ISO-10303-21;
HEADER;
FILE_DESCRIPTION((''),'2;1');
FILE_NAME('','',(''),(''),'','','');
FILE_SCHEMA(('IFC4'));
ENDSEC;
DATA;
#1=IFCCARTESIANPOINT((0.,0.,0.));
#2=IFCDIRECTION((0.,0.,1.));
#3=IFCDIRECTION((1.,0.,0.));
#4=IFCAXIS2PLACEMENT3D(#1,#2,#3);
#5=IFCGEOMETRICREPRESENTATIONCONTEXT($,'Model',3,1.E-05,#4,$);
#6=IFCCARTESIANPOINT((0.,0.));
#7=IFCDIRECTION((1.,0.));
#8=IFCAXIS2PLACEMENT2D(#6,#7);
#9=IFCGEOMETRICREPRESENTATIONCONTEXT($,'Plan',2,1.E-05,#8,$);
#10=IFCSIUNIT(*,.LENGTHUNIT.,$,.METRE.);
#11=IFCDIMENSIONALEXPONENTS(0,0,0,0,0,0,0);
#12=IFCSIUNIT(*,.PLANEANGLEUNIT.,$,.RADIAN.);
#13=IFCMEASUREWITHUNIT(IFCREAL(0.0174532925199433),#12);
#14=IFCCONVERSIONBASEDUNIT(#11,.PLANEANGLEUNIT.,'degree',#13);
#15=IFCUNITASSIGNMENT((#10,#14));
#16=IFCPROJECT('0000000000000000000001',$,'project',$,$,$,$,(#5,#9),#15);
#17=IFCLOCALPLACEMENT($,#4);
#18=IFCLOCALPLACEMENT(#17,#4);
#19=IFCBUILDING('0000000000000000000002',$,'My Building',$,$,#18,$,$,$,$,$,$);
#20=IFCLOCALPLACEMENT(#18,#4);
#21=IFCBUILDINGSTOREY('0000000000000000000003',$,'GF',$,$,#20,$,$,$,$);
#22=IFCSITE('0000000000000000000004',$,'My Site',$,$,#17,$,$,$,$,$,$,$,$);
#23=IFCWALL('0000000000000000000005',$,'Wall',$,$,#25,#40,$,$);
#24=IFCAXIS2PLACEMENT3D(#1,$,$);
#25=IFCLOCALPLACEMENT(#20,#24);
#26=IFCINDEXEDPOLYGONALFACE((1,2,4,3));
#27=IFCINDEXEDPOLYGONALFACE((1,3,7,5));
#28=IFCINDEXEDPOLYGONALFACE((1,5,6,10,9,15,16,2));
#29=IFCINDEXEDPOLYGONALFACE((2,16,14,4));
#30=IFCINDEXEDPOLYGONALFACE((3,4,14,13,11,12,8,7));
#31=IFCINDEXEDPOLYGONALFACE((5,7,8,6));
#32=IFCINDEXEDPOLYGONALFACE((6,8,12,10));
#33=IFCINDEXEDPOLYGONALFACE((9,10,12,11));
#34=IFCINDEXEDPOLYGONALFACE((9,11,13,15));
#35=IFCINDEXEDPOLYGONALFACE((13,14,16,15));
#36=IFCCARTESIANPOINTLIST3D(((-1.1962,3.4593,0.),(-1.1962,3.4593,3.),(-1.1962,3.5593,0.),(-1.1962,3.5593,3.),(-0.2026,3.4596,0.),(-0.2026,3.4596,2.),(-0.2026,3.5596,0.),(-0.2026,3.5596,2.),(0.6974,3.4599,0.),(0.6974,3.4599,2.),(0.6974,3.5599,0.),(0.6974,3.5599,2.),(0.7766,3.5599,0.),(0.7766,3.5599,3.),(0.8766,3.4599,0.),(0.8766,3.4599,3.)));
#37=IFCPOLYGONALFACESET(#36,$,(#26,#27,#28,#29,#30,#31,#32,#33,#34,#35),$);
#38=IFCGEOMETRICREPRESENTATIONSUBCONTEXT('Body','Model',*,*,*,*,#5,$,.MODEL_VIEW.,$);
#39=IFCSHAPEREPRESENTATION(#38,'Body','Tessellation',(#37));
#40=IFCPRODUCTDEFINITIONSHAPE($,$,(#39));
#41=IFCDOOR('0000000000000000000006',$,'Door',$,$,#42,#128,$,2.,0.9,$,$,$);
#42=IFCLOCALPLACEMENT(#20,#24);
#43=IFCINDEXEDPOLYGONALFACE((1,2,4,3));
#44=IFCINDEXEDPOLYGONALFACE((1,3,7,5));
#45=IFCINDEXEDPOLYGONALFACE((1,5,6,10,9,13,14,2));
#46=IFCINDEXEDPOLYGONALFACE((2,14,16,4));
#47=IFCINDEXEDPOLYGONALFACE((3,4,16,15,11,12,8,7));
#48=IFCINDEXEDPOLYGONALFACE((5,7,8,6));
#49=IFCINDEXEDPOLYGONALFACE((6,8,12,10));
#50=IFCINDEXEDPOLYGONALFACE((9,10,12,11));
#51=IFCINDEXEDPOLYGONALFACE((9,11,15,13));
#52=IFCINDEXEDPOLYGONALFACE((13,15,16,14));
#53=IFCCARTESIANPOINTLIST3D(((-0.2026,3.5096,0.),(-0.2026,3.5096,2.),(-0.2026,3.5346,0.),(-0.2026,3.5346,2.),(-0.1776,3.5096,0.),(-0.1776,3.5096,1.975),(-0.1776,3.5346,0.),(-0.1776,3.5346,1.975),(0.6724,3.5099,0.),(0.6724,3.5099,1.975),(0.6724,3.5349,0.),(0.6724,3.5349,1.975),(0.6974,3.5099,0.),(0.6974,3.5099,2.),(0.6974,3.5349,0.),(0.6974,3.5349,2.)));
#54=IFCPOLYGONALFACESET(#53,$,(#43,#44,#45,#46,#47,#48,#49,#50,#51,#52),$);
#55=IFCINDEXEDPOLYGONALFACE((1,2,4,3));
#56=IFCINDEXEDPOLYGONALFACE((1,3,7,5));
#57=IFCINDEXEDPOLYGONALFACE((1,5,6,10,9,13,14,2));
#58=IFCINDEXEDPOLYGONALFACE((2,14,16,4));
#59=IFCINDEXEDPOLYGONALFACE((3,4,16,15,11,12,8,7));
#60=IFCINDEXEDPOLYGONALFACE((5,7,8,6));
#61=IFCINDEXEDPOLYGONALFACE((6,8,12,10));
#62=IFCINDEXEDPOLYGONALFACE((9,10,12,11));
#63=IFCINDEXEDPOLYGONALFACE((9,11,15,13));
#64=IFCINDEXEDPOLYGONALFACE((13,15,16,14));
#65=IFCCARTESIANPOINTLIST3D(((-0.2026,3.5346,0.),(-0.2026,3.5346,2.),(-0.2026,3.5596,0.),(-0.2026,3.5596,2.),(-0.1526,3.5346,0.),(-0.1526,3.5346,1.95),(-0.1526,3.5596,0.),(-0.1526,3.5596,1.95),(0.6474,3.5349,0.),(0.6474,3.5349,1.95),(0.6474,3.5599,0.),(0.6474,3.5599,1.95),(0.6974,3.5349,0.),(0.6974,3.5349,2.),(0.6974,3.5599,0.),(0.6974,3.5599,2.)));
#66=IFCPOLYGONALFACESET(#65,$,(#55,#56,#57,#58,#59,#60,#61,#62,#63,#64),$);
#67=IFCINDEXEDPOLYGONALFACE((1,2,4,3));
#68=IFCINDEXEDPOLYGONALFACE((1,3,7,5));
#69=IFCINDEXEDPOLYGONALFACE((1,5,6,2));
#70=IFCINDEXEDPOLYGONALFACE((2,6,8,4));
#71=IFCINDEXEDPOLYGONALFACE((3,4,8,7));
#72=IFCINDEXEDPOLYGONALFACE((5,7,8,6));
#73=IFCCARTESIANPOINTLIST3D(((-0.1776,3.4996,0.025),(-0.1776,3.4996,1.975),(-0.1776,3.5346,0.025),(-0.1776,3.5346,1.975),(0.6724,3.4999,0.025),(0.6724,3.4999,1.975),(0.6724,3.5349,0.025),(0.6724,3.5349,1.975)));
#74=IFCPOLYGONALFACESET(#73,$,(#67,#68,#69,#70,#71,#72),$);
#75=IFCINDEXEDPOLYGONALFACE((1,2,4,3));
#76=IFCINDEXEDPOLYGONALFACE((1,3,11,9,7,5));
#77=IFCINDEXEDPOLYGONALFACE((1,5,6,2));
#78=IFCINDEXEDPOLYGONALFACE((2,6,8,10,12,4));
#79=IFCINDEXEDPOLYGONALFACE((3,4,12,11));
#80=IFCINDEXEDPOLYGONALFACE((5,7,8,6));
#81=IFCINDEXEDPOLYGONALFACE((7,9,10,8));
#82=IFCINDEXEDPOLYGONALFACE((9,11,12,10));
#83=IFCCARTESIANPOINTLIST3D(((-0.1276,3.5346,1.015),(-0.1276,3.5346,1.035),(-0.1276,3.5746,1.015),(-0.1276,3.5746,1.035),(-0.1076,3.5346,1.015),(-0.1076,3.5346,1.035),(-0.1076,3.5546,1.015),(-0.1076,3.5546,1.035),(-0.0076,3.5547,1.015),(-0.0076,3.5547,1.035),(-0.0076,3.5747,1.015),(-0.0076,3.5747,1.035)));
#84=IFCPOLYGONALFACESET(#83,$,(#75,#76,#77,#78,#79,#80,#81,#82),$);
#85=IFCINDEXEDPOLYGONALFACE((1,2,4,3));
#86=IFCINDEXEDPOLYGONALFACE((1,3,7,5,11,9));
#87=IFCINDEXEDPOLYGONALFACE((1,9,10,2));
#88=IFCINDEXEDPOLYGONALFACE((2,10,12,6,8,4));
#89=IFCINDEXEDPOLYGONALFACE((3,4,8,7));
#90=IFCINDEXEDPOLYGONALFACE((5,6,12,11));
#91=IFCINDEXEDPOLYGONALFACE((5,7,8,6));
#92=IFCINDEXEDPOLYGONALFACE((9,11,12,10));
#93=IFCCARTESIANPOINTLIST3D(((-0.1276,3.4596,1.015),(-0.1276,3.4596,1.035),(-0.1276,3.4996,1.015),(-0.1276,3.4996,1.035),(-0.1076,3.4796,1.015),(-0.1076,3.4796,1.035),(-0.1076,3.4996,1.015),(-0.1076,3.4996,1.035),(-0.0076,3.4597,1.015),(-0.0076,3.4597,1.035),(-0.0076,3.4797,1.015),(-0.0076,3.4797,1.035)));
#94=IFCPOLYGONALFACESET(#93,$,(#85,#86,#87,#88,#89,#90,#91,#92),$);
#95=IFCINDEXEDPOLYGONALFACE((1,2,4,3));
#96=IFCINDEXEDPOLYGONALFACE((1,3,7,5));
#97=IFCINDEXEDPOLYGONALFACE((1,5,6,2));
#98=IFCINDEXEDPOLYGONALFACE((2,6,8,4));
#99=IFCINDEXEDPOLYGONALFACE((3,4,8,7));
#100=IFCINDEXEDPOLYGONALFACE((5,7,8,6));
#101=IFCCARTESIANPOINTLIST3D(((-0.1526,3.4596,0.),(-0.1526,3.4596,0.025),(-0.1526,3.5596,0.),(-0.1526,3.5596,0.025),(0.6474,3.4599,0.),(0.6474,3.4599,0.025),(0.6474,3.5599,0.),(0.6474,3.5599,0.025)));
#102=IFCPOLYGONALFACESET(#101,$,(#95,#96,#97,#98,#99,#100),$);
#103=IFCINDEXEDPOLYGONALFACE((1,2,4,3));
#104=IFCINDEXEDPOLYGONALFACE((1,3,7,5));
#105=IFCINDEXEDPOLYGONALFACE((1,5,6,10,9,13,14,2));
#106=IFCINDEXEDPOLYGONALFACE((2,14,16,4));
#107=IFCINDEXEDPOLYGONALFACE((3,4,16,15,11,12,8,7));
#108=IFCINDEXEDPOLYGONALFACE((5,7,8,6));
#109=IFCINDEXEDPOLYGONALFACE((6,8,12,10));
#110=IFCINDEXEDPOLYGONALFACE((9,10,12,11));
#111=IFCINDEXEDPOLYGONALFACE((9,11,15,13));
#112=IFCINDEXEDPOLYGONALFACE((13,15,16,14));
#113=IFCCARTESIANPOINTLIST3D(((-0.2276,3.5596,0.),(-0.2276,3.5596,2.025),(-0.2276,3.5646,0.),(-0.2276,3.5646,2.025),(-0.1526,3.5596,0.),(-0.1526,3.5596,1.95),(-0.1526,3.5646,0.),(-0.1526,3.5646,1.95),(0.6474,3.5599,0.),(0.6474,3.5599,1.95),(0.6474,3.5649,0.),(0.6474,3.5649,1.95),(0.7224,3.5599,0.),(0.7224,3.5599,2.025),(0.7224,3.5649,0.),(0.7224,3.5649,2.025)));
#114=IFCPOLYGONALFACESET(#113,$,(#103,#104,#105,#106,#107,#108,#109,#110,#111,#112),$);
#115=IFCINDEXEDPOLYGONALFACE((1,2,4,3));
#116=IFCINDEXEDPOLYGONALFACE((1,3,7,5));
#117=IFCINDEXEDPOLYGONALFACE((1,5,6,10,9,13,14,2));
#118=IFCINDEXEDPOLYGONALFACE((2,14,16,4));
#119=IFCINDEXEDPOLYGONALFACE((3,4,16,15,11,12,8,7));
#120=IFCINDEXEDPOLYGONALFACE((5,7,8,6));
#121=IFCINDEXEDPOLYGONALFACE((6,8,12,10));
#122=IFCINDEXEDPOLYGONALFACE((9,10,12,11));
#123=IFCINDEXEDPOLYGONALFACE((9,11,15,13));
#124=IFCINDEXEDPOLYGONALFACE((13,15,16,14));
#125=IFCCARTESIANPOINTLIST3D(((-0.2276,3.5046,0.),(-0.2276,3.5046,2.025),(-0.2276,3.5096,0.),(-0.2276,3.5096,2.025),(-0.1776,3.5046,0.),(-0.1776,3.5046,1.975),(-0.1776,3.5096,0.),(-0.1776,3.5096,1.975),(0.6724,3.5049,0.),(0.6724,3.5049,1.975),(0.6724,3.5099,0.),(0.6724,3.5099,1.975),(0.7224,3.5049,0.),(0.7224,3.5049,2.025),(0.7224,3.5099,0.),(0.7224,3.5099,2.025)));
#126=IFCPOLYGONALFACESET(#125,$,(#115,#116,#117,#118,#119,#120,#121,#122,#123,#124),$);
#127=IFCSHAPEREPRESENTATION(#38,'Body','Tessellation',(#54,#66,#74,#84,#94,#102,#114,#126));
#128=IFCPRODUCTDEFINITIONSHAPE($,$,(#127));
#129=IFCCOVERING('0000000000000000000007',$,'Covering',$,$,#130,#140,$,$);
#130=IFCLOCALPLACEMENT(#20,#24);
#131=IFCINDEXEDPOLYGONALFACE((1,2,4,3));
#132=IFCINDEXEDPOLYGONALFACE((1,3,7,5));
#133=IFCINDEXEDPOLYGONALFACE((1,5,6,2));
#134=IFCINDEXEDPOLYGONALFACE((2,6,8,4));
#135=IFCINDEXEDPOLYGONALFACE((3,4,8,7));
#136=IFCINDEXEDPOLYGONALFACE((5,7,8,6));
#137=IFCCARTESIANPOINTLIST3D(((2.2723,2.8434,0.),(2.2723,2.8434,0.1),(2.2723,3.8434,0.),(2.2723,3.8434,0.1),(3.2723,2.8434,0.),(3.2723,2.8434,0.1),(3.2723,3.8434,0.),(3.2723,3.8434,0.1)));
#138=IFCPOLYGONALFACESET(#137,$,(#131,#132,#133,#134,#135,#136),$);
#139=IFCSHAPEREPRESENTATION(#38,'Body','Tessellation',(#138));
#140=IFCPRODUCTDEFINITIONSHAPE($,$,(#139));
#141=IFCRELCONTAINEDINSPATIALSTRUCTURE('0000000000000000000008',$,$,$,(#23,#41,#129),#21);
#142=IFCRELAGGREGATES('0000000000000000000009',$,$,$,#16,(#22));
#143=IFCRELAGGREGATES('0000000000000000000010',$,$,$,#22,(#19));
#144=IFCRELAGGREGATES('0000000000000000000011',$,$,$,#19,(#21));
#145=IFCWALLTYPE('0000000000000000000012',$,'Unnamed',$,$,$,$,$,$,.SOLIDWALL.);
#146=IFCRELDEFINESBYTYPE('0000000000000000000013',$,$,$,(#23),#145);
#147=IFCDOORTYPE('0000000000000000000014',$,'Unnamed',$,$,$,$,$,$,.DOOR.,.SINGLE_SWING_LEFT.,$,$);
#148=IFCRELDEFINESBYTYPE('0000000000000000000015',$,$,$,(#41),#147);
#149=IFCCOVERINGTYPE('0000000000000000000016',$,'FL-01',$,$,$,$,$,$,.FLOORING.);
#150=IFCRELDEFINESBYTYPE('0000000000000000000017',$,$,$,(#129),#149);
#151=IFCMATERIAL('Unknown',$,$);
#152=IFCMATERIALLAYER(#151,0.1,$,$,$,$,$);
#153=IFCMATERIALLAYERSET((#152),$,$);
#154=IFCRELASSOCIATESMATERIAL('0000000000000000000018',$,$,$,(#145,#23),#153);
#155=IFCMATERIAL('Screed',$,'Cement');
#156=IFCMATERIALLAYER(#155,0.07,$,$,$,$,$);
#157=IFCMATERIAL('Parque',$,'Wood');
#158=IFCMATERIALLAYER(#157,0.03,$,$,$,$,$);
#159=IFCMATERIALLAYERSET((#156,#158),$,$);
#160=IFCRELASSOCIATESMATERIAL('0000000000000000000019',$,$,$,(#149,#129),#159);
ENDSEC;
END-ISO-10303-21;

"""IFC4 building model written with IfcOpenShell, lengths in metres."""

from ifc_helpers import new_model, entity, si_unit, converted_unit, frame, origin_with_axes, origin_2d_with_axis, place, context, subcontext, project, spatial, line, indexed_curve, outline, extrude, shape, source, transform, mapped, material, layer, layer_set, layer_usage, type_object, type_shapes, element, fill, save


model = new_model("IFC4")

# Units and contexts
model_context = context("Model", 3, precision=1e-05, world=origin_with_axes())
plan_context = context("Plan", 2, precision=1e-05, world=origin_2d_with_axis())
body_context_1 = subcontext(model_context, "Body", "Model", "MODEL_VIEW")
body_context_2 = subcontext(plan_context, "Body", "Plan", "PLAN_VIEW")
ifc_project = project(units=[si_unit("LENGTHUNIT", "METRE"), converted_unit("PLANEANGLEUNIT", "degree", entity("IfcReal", 0.0174532925199433), si_unit("PLANEANGLEUNIT", "RADIAN"), dimensions=[0, 0, 0, 0, 0, 0, 0])], contexts=[model_context, plan_context])

# Site, building, storey
site_placement = place(None, origin_with_axes())
site = spatial("IfcSite", under=ifc_project, at=site_placement, Name="My Site")
building_placement = place(site_placement, origin_with_axes())
building = spatial("IfcBuilding", under=site, at=building_placement, Name="My Building")
storey_placement = place(building_placement, origin_with_axes())
storey = spatial("IfcBuildingStorey", under=building, at=storey_placement, Name="GF")

# Shared definitions
ifc_material_1 = material(Name="Unknown")

# Shared definitions
ifc_layer_1 = layer(ifc_material_1, 0.1)
ifc_layer_set_1 = layer_set([ifc_layer_1])
wall_type = type_object("IfcWallType", Name="Unnamed", PredefinedType="SOLIDWALL", material=ifc_layer_set_1)

# Wall, opening, door
ifc_layer_usage_1 = layer_usage(ifc_layer_set_1, "AXIS2", "POSITIVE", 0.0)
wall_1_placement = place(storey_placement, frame((0.7766, 3.5599, 0.0), z_axis=(0.0, 0.0, 1.0), x_axis=(-1.0, -0.000309, 0.0)))
wall_1 = element("IfcWall", 1, at=wall_1_placement, inside=storey, type_object=wall_type, material=ifc_layer_usage_1, Name="Wall", context=body_context_1, shape_type="SweptSolid", body=[
    extrude(outline(indexed_curve([(0.0, 0.0), (-0.1, 0.1), (1.9728, 0.1), (1.9728, 0.0)], segments=[line(1, 2, 3, 4, 1)])), origin_with_axes(), (0.0, 0.0, 1.0), 3.0),
])
shared_shape_1 = source(origin_with_axes(), body_context_1, "Body", "SweptSolid", [
    extrude(outline(indexed_curve([(0.0, 0.0), (0.9, 0.0), (0.9, 2.0), (0.0, 2.0)], segments=[line(1, 2, 3, 4, 1)])), frame((0.0, -0.6, 0.0), z_axis=(0.0, -1.0, 0.0), x_axis=(1.0, 0.0, 0.0)), (0.0, 0.0, -1.0), 1.2),
])
opening_1_placement = place(wall_1_placement, frame((0.0792, 0.0, 0.0), z_axis=(0.0, 0.0, 1.0), x_axis=(1.0, 0.0, 0.0)))
opening_1 = element("IfcOpeningElement", 2, at=opening_1_placement, cuts=wall_1, PredefinedType="OPENING", context=body_context_1, shape_type="MappedRepresentation", body=[
    mapped(shared_shape_1, transform((0.0, 0.0, 0.0), x_axis=(1.0, 0.0, 0.0), y_axis=(0.0, 1.0, 0.0), z_axis=(0.0, 0.0, 1.0), scale=1.0)),
])
door_type = type_object("IfcDoorType", Name="Unnamed", OperationType="SINGLE_SWING_LEFT", PredefinedType="DOOR")
shared_shape_2 = source(origin_with_axes(), body_context_1, "Body", "SweptSolid", [
    extrude(outline(indexed_curve([(0.0, 0.0), (0.0, 2.0), (0.9, 2.0), (0.9, 0.0), (0.875, 0.0), (0.875, 1.975), (0.025, 1.975), (0.025, 0.0)], segments=[line(1, 2, 3, 4, 5, 6, 7, 8, 1)])), frame((0.0, 0.025, 0.0), z_axis=(0.0, -1.0, 0.0), x_axis=(1.0, 0.0, 0.0)), (0.0, 0.0, -1.0), 0.025),
    extrude(outline(indexed_curve([(0.0, 0.0), (0.0, 2.0), (0.9, 2.0), (0.9, 0.0), (0.85, 0.0), (0.85, 1.95), (0.05, 1.95), (0.05, 0.0)], segments=[line(1, 2, 3, 4, 5, 6, 7, 8, 1)])), frame((0.0, 0.0, 0.0), z_axis=(0.0, -1.0, 0.0), x_axis=(1.0, 0.0, 0.0)), (0.0, 0.0, -1.0), 0.025),
    extrude(outline(indexed_curve([(0.0, 0.0), (0.85, 0.0), (0.85, 0.035), (0.0, 0.035)], segments=[line(1, 2, 3, 4, 1)])), frame((0.025, 0.025, 0.025), z_axis=(0.0, 0.0, 1.0), x_axis=(1.0, 0.0, 0.0)), (0.0, 0.0, 1.0), 1.95),
    extrude(outline(indexed_curve([(0.0, 0.0), (0.0, -0.04), (-0.12, -0.04), (-0.12, -0.02), (-0.02, -0.02), (-0.02, 0.0)], segments=[line(1, 2, 3, 4, 5, 6, 1)])), frame((0.825, 0.025, 1.015), z_axis=(0.0, 0.0, 1.0), x_axis=(1.0, 0.0, 0.0)), (0.0, 0.0, 1.0), 0.02),
    extrude(outline(indexed_curve([(0.0, 0.0), (0.0, 0.04), (-0.12, 0.04), (-0.12, 0.02), (-0.02, 0.02), (-0.02, 0.0)], segments=[line(1, 2, 3, 4, 5, 6, 1)])), frame((0.825, 0.06, 1.015), z_axis=(0.0, 0.0, 1.0), x_axis=(1.0, 0.0, 0.0)), (0.0, 0.0, 1.0), 0.02),
    extrude(outline(indexed_curve([(0.0, 0.0), (0.8, 0.0), (0.8, 0.1), (0.0, 0.1)], segments=[line(1, 2, 3, 4, 1)])), frame((0.05, 0.0, 0.0), z_axis=(0.0, 0.0, 1.0), x_axis=(1.0, 0.0, 0.0)), (0.0, 0.0, 1.0), 0.025),
    extrude(outline(indexed_curve([(0.0, 0.0), (0.0, 2.025), (0.95, 2.025), (0.95, 0.0), (0.875, 0.0), (0.875, 1.95), (0.075, 1.95), (0.075, 0.0)], segments=[line(1, 2, 3, 4, 5, 6, 7, 8, 1)])), frame((-0.025, -0.005, 0.0), z_axis=(0.0, -1.0, 0.0), x_axis=(1.0, 0.0, 0.0)), (0.0, 0.0, -1.0), 0.005),
    extrude(outline(indexed_curve([(0.0, 0.0), (0.0, 2.025), (0.95, 2.025), (0.95, 0.0), (0.9, 0.0), (0.9, 1.975), (0.05, 1.975), (0.05, 0.0)], segments=[line(1, 2, 3, 4, 5, 6, 7, 8, 1)])), frame((-0.025, 0.05, 0.0), z_axis=(0.0, -1.0, 0.0), x_axis=(1.0, 0.0, 0.0)), (0.0, 0.0, -1.0), 0.005),
])
shared_shape_3 = source(origin_with_axes(), body_context_2, "Body", "Curve2D", [
    entity("IfcIndexedPolyCurve", entity("IfcCartesianPointList2D", [[0.0, 0.0], [0.0, 0.05], [0.025, 0.05], [0.025, 0.025], [0.05, 0.025], [0.05, 0.0]]), [entity("IfcLineIndex", [1, 2, 3, 4, 5, 6, 1])]),
    entity("IfcIndexedPolyCurve", entity("IfcCartesianPointList2D", [[0.9, 0.0], [0.9, 0.05], [0.875, 0.05], [0.875, 0.025], [0.85, 0.025], [0.85, 0.0]]), [entity("IfcLineIndex", [1, 2, 3, 4, 5, 6, 1])]),
    entity("IfcTrimmedCurve", entity("IfcEllipse", entity("IfcAxis2Placement2D", entity("IfcCartesianPoint", [0.06, 0.05]), entity("IfcDirection", [1.0, 0.0])), 0.815, 0.85), [entity("IfcCartesianPoint", [0.875, 0.05])], [entity("IfcCartesianPoint", [0.06, 0.9])], True, "CARTESIAN"),
    entity("IfcIndexedPolyCurve", entity("IfcCartesianPointList2D", [[0.025, 0.05], [0.06, 0.05], [0.06, 0.9], [0.025, 0.9]]), [entity("IfcLineIndex", [1, 2, 3, 4, 1])]),
])
type_shapes(door_type, [shared_shape_2, shared_shape_3])
door_placement = place(opening_1_placement, frame((0.0, 0.0, 0.0), z_axis=(0.0, 0.0, 1.0), x_axis=(1.0, 0.0, 0.0)))
door = element("IfcDoor", 3, at=door_placement, inside=storey, type_object=door_type, Name="Door", OverallHeight=2.0, OverallWidth=0.9, shapes=[
    shape(body_context_1, "Body", "MappedRepresentation", [mapped(shared_shape_2, transform((0.0, 0.0, 0.0), x_axis=(1.0, 0.0, 0.0), y_axis=(0.0, 1.0, 0.0), z_axis=(0.0, 0.0, 1.0), scale=1.0))]),
    shape(body_context_2, "Body", "MappedRepresentation", [mapped(shared_shape_3, transform((0.0, 0.0, 0.0), x_axis=(1.0, 0.0, 0.0), y_axis=(0.0, 1.0, 0.0), z_axis=(0.0, 0.0, 1.0), scale=1.0))]),
])
fill(opening_1, door)

# Covering
ifc_material_2 = material(Name="Screed", Category="Cement")
ifc_layer_2 = layer(ifc_material_2, 0.07)
ifc_material_3 = material(Name="Parque", Category="Wood")
ifc_layer_3 = layer(ifc_material_3, 0.03)
ifc_layer_set_2 = layer_set([ifc_layer_2, ifc_layer_3])
ifc_layer_usage_2 = layer_usage(ifc_layer_set_2, "AXIS3", "POSITIVE", 0.0)
covering_type = type_object("IfcCoveringType", Name="FL-01", PredefinedType="FLOORING", material=ifc_layer_set_2)
covering_placement = place(storey_placement, frame((2.2723, 2.8434, 0.0), z_axis=(0.0, 0.0, 1.0), x_axis=(1.0, 0.0, 0.0)))
element("IfcCovering", 4, at=covering_placement, inside=storey, type_object=covering_type, material=ifc_layer_usage_2, Name="Covering", context=body_context_1, shape_type="SweptSolid", body=[
    extrude(outline(indexed_curve([(0.0, 0.0), (1.0, 0.0), (1.0, 1.0), (0.0, 1.0), (0.0, 0.0)])), None, (0.0, 0.0, 1.0), 0.1),
])

save(model, "model.ifc")
